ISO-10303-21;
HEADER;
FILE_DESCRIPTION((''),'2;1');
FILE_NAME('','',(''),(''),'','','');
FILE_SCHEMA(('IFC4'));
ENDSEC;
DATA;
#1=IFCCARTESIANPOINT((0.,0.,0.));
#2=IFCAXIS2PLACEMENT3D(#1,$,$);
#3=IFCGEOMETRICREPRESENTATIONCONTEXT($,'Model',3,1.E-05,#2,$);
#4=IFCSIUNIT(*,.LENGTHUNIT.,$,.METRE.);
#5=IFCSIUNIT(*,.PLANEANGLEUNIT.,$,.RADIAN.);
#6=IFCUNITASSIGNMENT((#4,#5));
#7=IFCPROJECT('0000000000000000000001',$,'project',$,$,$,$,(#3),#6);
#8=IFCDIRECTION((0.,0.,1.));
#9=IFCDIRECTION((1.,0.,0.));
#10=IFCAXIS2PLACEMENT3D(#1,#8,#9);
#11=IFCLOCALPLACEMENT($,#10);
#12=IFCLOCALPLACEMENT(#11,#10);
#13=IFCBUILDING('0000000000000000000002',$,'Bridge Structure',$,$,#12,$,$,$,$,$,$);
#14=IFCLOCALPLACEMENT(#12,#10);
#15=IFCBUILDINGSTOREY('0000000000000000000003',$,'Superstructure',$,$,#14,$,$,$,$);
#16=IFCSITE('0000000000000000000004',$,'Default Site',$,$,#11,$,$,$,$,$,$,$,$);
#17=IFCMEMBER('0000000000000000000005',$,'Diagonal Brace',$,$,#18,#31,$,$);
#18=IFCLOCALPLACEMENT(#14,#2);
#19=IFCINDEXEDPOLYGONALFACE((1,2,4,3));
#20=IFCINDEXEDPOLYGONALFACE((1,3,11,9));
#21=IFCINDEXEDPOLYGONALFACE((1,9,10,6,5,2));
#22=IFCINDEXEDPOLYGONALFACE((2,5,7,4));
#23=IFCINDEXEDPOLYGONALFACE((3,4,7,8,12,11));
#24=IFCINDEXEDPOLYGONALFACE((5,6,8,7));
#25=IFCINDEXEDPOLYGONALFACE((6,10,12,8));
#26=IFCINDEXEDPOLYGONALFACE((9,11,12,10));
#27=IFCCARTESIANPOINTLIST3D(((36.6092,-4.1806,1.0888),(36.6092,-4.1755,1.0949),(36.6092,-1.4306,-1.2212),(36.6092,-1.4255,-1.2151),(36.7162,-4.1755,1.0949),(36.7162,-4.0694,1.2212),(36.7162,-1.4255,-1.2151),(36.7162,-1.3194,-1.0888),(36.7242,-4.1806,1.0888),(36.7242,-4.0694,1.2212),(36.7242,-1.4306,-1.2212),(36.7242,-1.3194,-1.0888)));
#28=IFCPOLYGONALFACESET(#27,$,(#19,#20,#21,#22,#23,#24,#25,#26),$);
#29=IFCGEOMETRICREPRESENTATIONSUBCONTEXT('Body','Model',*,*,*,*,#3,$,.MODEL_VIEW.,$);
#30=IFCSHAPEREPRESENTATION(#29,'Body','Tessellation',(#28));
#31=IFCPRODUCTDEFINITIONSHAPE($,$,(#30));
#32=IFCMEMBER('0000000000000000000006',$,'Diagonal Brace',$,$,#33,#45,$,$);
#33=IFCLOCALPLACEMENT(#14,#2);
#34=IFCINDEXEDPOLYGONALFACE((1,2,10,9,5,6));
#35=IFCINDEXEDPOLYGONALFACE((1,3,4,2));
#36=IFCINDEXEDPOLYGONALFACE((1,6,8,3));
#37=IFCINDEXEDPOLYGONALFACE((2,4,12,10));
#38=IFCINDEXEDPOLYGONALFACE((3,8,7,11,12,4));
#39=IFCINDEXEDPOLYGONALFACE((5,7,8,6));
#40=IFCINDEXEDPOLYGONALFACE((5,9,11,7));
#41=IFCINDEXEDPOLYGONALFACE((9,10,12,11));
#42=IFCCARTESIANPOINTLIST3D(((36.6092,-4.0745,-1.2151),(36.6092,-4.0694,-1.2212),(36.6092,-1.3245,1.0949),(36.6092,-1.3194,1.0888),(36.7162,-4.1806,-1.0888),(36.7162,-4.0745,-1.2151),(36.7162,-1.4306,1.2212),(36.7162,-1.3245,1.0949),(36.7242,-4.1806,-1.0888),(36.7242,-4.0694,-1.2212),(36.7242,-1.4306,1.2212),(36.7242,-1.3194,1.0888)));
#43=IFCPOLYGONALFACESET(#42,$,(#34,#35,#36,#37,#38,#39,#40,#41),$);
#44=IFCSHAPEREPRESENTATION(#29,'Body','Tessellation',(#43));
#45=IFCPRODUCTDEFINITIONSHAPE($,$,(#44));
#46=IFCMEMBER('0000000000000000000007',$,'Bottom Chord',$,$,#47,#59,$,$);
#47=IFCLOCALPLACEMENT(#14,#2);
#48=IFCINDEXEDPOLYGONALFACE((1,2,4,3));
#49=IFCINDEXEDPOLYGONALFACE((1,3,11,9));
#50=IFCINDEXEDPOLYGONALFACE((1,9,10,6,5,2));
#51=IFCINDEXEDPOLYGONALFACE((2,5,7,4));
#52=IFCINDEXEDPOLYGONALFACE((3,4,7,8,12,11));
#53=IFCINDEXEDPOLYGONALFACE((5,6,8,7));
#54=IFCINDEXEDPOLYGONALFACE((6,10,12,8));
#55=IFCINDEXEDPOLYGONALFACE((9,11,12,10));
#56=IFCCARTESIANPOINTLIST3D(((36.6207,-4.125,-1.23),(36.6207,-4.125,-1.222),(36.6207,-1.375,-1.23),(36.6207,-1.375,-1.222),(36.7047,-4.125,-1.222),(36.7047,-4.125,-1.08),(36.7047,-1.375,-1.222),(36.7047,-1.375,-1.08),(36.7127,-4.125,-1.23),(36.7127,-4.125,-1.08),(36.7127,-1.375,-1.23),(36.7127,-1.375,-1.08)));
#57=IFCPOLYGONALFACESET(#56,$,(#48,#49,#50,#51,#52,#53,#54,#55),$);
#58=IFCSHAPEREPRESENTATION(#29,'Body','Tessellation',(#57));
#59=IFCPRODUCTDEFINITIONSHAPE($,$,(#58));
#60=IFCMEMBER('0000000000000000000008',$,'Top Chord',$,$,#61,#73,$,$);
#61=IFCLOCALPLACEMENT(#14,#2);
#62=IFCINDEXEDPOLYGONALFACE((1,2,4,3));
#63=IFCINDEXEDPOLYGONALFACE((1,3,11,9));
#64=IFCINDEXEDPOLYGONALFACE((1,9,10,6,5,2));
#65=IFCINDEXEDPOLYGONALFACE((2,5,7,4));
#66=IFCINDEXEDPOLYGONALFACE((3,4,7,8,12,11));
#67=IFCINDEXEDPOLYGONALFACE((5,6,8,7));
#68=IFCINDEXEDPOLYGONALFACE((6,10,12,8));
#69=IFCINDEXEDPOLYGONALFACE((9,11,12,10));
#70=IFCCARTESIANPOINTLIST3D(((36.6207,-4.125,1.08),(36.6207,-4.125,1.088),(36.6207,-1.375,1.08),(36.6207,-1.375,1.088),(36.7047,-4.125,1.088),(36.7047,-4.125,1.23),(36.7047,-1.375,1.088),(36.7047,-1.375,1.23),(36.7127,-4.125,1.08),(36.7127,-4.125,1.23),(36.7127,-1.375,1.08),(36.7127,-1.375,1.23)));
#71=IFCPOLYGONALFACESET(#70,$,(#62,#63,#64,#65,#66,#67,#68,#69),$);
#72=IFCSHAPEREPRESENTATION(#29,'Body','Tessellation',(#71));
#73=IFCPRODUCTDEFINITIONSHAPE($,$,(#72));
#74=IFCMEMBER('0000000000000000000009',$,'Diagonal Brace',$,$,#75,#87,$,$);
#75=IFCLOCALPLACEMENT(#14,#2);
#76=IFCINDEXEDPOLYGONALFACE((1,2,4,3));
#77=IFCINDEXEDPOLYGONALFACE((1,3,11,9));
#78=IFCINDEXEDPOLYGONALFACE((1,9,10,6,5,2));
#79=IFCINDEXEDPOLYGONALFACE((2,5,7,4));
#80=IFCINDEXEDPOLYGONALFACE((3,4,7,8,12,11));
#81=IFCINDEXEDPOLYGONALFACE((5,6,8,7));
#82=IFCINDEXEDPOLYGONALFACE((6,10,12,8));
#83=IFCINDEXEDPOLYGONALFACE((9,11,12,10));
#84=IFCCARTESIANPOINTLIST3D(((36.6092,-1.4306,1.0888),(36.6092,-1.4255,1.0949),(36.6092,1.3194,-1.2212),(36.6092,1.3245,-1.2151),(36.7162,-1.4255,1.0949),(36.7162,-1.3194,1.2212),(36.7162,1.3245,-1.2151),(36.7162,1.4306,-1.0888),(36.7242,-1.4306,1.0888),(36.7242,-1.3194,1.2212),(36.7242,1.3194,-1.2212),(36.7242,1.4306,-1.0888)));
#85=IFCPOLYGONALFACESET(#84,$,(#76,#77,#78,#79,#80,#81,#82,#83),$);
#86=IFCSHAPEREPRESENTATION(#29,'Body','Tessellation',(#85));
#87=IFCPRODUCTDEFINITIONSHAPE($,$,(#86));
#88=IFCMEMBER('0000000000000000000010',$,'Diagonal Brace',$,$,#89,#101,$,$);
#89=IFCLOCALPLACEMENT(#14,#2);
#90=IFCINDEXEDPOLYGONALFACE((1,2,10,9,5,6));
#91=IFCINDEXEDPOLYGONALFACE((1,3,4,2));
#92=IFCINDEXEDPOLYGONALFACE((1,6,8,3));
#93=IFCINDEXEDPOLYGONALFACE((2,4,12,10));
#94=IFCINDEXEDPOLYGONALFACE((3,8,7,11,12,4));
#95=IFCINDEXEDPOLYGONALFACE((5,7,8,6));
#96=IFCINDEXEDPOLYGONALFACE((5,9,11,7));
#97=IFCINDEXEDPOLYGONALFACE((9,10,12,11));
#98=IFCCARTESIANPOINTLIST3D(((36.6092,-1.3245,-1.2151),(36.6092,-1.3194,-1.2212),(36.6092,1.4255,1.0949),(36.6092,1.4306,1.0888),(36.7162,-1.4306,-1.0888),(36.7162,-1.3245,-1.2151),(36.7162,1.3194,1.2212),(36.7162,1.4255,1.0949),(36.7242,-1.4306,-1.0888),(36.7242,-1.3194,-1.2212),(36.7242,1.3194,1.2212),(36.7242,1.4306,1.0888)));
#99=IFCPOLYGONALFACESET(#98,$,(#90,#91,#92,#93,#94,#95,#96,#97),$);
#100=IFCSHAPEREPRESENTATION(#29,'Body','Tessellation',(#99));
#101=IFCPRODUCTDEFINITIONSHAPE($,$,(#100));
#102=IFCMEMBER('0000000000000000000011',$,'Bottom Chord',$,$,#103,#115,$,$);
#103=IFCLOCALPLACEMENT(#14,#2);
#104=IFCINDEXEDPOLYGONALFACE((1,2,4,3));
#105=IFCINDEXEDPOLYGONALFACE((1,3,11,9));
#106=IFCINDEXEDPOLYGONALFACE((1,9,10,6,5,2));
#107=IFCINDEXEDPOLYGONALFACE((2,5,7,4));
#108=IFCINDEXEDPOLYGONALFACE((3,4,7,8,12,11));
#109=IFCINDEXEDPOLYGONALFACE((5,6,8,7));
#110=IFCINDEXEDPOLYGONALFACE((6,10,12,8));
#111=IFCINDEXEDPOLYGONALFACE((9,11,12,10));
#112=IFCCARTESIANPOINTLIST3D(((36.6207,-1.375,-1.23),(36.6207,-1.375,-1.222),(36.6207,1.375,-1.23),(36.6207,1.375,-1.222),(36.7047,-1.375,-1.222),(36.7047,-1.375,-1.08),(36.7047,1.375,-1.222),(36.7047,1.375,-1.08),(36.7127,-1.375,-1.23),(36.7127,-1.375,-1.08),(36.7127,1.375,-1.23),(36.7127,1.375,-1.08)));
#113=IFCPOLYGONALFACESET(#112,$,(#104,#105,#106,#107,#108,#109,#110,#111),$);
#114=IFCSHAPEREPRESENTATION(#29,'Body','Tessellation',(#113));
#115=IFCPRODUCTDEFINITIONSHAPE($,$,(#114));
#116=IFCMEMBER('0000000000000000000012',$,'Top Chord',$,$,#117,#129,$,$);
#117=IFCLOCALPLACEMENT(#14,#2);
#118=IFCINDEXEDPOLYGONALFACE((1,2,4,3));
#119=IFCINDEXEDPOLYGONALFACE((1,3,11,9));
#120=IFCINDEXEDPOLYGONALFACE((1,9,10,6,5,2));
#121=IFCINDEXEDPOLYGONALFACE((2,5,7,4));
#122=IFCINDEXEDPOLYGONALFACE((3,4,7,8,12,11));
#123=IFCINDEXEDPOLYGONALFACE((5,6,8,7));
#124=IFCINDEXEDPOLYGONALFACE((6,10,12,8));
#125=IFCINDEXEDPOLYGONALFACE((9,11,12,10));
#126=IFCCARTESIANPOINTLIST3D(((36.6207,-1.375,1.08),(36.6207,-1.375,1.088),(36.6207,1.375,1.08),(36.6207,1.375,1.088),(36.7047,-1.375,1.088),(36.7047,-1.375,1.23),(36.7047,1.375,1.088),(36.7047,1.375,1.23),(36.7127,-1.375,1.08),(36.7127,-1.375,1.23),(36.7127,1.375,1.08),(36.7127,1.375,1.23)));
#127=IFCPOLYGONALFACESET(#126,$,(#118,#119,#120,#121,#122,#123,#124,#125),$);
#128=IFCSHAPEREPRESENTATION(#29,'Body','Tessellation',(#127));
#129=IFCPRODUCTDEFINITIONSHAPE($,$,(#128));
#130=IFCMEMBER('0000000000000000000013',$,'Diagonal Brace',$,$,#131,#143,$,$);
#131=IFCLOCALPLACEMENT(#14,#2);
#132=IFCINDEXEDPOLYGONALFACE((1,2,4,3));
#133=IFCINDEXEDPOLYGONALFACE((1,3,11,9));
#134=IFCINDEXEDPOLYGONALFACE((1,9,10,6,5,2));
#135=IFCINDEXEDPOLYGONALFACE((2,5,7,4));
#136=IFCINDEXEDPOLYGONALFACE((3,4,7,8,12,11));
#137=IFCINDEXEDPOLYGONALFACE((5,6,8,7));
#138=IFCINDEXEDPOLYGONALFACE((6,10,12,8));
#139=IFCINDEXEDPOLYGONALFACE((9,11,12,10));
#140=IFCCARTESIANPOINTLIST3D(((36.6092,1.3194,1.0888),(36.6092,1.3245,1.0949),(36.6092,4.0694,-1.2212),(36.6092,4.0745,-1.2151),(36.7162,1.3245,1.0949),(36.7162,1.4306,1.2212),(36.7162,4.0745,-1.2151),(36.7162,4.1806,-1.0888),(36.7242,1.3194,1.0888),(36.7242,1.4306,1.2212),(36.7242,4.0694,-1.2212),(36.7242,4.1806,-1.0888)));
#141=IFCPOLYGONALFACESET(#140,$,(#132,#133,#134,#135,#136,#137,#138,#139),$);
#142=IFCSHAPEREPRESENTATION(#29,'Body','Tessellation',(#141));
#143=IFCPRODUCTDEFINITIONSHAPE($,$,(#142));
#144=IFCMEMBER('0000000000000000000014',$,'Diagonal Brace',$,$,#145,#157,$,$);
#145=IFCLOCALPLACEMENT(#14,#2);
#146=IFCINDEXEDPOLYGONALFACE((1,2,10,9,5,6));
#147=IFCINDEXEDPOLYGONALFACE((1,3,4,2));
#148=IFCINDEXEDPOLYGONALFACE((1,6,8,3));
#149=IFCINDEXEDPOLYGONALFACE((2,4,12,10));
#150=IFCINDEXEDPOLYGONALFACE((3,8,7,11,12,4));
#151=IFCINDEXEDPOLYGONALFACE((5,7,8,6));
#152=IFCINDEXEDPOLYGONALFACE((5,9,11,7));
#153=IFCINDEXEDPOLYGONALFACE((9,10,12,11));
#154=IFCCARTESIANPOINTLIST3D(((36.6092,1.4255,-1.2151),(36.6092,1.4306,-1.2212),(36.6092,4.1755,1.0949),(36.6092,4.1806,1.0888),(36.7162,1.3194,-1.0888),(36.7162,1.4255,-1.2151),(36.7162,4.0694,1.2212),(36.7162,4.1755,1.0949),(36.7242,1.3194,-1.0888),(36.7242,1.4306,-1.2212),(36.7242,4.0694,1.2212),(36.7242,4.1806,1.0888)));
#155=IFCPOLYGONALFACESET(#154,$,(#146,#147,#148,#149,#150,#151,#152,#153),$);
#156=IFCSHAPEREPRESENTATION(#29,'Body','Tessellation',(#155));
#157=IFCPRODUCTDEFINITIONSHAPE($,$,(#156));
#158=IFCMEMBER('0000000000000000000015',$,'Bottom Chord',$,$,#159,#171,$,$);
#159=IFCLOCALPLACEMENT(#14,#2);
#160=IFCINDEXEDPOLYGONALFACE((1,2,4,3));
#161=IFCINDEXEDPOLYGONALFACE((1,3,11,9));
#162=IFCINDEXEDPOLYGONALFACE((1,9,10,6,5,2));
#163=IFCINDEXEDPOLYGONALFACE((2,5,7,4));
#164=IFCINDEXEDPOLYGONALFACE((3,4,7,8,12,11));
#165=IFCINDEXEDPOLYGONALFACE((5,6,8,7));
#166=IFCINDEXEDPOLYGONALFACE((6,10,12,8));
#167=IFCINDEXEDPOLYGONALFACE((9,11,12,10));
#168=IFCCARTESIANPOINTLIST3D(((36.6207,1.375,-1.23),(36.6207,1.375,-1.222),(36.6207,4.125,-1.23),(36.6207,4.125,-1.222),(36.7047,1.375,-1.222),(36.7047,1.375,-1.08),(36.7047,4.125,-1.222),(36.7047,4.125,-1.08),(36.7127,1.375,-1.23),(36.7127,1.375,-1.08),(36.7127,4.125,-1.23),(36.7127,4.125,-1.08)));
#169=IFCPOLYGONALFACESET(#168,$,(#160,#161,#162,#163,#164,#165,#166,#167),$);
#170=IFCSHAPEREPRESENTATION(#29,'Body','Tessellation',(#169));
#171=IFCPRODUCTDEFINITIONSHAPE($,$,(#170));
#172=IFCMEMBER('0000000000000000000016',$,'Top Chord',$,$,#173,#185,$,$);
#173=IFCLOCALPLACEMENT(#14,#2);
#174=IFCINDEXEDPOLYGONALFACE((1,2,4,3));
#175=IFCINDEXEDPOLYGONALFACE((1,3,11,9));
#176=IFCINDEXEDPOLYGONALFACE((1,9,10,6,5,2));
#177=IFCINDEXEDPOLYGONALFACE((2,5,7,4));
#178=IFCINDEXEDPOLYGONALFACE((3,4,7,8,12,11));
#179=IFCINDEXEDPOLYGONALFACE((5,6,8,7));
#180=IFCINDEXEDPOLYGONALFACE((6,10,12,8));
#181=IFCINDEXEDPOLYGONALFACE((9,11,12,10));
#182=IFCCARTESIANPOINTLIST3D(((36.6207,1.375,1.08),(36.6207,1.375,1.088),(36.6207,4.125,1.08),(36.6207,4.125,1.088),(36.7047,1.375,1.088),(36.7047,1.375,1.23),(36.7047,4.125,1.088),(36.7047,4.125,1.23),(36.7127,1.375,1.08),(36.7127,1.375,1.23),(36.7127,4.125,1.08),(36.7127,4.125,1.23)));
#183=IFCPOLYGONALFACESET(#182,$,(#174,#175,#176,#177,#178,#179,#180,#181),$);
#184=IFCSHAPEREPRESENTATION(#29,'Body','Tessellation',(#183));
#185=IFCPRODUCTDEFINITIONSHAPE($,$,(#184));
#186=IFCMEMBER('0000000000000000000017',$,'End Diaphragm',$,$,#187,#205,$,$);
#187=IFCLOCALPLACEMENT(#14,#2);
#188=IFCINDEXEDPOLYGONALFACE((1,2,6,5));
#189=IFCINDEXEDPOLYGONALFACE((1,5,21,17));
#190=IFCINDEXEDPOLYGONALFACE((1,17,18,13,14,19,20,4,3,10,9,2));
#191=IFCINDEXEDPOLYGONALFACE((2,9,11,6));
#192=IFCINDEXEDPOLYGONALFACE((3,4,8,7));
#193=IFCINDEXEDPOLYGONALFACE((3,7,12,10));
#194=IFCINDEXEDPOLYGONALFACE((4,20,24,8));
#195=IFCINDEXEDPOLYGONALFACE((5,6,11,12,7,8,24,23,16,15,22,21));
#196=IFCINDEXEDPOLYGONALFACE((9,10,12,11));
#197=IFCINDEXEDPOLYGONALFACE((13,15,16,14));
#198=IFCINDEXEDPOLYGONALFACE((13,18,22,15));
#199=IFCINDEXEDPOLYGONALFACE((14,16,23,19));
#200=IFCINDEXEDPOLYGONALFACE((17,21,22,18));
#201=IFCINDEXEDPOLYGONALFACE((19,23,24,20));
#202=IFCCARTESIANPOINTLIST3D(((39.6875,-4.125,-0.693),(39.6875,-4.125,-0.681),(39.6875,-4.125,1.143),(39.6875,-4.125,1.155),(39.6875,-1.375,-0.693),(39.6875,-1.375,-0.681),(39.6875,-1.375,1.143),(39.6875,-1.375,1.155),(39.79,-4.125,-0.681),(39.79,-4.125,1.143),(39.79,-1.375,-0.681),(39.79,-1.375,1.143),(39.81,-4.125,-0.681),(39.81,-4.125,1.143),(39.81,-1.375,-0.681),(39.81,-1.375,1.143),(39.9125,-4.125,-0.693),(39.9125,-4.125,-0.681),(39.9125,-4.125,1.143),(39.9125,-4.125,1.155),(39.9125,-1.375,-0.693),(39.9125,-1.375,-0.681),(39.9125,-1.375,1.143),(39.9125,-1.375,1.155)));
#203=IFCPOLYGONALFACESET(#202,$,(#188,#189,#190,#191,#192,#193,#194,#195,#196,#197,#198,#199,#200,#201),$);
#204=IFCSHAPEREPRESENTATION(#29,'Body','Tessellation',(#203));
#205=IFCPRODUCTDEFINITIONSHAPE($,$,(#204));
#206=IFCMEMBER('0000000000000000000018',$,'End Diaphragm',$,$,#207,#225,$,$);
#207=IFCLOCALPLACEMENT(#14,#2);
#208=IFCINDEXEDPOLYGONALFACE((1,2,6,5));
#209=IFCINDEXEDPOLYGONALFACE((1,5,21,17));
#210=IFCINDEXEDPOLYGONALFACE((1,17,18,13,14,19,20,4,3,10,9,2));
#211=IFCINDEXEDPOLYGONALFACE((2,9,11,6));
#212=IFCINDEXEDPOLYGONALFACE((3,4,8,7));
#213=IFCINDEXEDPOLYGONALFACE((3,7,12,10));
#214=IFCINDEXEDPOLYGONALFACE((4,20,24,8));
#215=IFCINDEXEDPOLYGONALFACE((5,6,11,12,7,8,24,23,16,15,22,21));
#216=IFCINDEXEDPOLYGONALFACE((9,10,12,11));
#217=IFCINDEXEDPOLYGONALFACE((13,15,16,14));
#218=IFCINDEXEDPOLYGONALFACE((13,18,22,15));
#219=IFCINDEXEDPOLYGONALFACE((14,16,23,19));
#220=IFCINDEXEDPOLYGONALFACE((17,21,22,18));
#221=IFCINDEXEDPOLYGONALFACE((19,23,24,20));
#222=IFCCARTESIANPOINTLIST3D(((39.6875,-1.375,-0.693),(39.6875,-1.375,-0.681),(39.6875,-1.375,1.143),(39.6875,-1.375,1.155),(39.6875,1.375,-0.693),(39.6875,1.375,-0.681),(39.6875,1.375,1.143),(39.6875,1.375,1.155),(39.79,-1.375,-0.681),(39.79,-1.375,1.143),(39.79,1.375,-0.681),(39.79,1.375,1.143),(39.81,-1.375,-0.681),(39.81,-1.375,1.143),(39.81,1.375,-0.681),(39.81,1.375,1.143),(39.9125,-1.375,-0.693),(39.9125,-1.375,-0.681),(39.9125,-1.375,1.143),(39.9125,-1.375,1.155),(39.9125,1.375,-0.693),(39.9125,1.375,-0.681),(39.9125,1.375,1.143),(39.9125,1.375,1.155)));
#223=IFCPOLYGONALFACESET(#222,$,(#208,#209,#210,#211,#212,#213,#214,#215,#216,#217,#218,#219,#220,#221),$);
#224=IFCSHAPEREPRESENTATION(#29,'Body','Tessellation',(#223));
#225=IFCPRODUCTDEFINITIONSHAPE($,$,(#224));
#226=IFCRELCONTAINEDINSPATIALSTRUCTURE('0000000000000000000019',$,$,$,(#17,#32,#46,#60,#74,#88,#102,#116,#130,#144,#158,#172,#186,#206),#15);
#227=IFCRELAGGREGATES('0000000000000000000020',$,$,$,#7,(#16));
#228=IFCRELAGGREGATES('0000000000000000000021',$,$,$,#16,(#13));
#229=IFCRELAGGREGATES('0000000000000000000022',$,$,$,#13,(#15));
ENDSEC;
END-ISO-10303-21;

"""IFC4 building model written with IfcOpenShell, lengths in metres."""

from ifc_helpers import new_model, si_unit, frame, origin, origin_with_axes, origin_2d_with_axis, place, context, subcontext, project, spatial, i_section, l_section, extrude, element, save


model = new_model("IFC4")

# Units and contexts
model_context = context("Model", 3, precision=1e-05, world=origin())
body_context = subcontext(model_context, "Body", "Model", "MODEL_VIEW")
ifc_project = project(units=[si_unit("LENGTHUNIT", "METRE"), si_unit("PLANEANGLEUNIT", "RADIAN")], contexts=[model_context])

# Site, building, storey
site_placement = place(None, origin_with_axes())
site = spatial("IfcSite", under=ifc_project, at=site_placement, Name="Default Site")
building_placement = place(site_placement, origin_with_axes())
building = spatial("IfcBuilding", under=site, at=building_placement, Name="Bridge Structure")
storey_placement = place(building_placement, origin_with_axes())
storey = spatial("IfcBuildingStorey", under=building, at=storey_placement, Name="Superstructure")

# Members
for number, where, z_axis, x_axis, name in (
    (1, (36.6667, -4.125, 1.155), (0.0, 0.765705, -0.643192), (-1.0, 0.0, 0.0), "Diagonal Brace"),
    (2, (36.6667, -4.125, -1.155), (0.0, 0.765705, 0.643192), (-1.0, 0.0, 0.0), "Diagonal Brace"),
):
    element("IfcMember", number, at=place(storey_placement, frame(where, z_axis=z_axis, x_axis=x_axis)), inside=storey, Name=name, context=body_context, shape_type="SweptSolid", body=[
        extrude(l_section(Depth=0.173, Width=0.115, Thickness=0.008, at=origin_2d_with_axis()), origin_with_axes(), (0.0, 0.0, 1.0), 3.5915),
    ])
for number, where, z_axis, x_axis, name in (
    (3, (36.6667, -4.125, -1.155), (0.0, 1.0, 0.0), (-1.0, 0.0, 0.0), "Bottom Chord"),
    (4, (36.6667, -4.125, 1.155), (0.0, 1.0, 0.0), (-1.0, 0.0, 0.0), "Top Chord"),
):
    element("IfcMember", number, at=place(storey_placement, frame(where, z_axis=z_axis, x_axis=x_axis)), inside=storey, Name=name, context=body_context, shape_type="SweptSolid", body=[
        extrude(l_section(Depth=0.15, Width=0.092, Thickness=0.008, at=origin_2d_with_axis()), origin_with_axes(), (0.0, 0.0, 1.0), 2.75),
    ])
for number, where, z_axis, x_axis, name in (
    (5, (36.6667, -1.375, 1.155), (0.0, 0.765705, -0.643192), (-1.0, 0.0, 0.0), "Diagonal Brace"),
    (6, (36.6667, -1.375, -1.155), (0.0, 0.765705, 0.643192), (-1.0, 0.0, 0.0), "Diagonal Brace"),
):
    element("IfcMember", number, at=place(storey_placement, frame(where, z_axis=z_axis, x_axis=x_axis)), inside=storey, Name=name, context=body_context, shape_type="SweptSolid", body=[
        extrude(l_section(Depth=0.173, Width=0.115, Thickness=0.008, at=origin_2d_with_axis()), origin_with_axes(), (0.0, 0.0, 1.0), 3.5915),
    ])
for number, where, z_axis, x_axis, name in (
    (7, (36.6667, -1.375, -1.155), (0.0, 1.0, 0.0), (-1.0, 0.0, 0.0), "Bottom Chord"),
    (8, (36.6667, -1.375, 1.155), (0.0, 1.0, 0.0), (-1.0, 0.0, 0.0), "Top Chord"),
):
    element("IfcMember", number, at=place(storey_placement, frame(where, z_axis=z_axis, x_axis=x_axis)), inside=storey, Name=name, context=body_context, shape_type="SweptSolid", body=[
        extrude(l_section(Depth=0.15, Width=0.092, Thickness=0.008, at=origin_2d_with_axis()), origin_with_axes(), (0.0, 0.0, 1.0), 2.75),
    ])
for number, where, z_axis, x_axis, name in (
    (9, (36.6667, 1.375, 1.155), (0.0, 0.765705, -0.643192), (-1.0, 0.0, 0.0), "Diagonal Brace"),
    (10, (36.6667, 1.375, -1.155), (0.0, 0.765705, 0.643192), (-1.0, 0.0, 0.0), "Diagonal Brace"),
):
    element("IfcMember", number, at=place(storey_placement, frame(where, z_axis=z_axis, x_axis=x_axis)), inside=storey, Name=name, context=body_context, shape_type="SweptSolid", body=[
        extrude(l_section(Depth=0.173, Width=0.115, Thickness=0.008, at=origin_2d_with_axis()), origin_with_axes(), (0.0, 0.0, 1.0), 3.5915),
    ])
for number, where, z_axis, x_axis, name in (
    (11, (36.6667, 1.375, -1.155), (0.0, 1.0, 0.0), (-1.0, 0.0, 0.0), "Bottom Chord"),
    (12, (36.6667, 1.375, 1.155), (0.0, 1.0, 0.0), (-1.0, 0.0, 0.0), "Top Chord"),
):
    element("IfcMember", number, at=place(storey_placement, frame(where, z_axis=z_axis, x_axis=x_axis)), inside=storey, Name=name, context=body_context, shape_type="SweptSolid", body=[
        extrude(l_section(Depth=0.15, Width=0.092, Thickness=0.008, at=origin_2d_with_axis()), origin_with_axes(), (0.0, 0.0, 1.0), 2.75),
    ])
for number, where, z_axis, x_axis, name in (
    (13, (39.8, -4.125, 0.231), (0.0, 1.0, 0.0), (-1.0, 0.0, 0.0), "End Diaphragm"),
    (14, (39.8, -1.375, 0.231), (0.0, 1.0, 0.0), (-1.0, 0.0, 0.0), "End Diaphragm"),
):
    element("IfcMember", number, at=place(storey_placement, frame(where, z_axis=z_axis, x_axis=x_axis)), inside=storey, Name=name, context=body_context, shape_type="SweptSolid", body=[
        extrude(i_section(OverallWidth=0.225, OverallDepth=1.848, WebThickness=0.02, FlangeThickness=0.012, at=origin_2d_with_axis()), origin_with_axes(), (0.0, 0.0, 1.0), 2.75),
    ])

save(model, "model.ifc")
